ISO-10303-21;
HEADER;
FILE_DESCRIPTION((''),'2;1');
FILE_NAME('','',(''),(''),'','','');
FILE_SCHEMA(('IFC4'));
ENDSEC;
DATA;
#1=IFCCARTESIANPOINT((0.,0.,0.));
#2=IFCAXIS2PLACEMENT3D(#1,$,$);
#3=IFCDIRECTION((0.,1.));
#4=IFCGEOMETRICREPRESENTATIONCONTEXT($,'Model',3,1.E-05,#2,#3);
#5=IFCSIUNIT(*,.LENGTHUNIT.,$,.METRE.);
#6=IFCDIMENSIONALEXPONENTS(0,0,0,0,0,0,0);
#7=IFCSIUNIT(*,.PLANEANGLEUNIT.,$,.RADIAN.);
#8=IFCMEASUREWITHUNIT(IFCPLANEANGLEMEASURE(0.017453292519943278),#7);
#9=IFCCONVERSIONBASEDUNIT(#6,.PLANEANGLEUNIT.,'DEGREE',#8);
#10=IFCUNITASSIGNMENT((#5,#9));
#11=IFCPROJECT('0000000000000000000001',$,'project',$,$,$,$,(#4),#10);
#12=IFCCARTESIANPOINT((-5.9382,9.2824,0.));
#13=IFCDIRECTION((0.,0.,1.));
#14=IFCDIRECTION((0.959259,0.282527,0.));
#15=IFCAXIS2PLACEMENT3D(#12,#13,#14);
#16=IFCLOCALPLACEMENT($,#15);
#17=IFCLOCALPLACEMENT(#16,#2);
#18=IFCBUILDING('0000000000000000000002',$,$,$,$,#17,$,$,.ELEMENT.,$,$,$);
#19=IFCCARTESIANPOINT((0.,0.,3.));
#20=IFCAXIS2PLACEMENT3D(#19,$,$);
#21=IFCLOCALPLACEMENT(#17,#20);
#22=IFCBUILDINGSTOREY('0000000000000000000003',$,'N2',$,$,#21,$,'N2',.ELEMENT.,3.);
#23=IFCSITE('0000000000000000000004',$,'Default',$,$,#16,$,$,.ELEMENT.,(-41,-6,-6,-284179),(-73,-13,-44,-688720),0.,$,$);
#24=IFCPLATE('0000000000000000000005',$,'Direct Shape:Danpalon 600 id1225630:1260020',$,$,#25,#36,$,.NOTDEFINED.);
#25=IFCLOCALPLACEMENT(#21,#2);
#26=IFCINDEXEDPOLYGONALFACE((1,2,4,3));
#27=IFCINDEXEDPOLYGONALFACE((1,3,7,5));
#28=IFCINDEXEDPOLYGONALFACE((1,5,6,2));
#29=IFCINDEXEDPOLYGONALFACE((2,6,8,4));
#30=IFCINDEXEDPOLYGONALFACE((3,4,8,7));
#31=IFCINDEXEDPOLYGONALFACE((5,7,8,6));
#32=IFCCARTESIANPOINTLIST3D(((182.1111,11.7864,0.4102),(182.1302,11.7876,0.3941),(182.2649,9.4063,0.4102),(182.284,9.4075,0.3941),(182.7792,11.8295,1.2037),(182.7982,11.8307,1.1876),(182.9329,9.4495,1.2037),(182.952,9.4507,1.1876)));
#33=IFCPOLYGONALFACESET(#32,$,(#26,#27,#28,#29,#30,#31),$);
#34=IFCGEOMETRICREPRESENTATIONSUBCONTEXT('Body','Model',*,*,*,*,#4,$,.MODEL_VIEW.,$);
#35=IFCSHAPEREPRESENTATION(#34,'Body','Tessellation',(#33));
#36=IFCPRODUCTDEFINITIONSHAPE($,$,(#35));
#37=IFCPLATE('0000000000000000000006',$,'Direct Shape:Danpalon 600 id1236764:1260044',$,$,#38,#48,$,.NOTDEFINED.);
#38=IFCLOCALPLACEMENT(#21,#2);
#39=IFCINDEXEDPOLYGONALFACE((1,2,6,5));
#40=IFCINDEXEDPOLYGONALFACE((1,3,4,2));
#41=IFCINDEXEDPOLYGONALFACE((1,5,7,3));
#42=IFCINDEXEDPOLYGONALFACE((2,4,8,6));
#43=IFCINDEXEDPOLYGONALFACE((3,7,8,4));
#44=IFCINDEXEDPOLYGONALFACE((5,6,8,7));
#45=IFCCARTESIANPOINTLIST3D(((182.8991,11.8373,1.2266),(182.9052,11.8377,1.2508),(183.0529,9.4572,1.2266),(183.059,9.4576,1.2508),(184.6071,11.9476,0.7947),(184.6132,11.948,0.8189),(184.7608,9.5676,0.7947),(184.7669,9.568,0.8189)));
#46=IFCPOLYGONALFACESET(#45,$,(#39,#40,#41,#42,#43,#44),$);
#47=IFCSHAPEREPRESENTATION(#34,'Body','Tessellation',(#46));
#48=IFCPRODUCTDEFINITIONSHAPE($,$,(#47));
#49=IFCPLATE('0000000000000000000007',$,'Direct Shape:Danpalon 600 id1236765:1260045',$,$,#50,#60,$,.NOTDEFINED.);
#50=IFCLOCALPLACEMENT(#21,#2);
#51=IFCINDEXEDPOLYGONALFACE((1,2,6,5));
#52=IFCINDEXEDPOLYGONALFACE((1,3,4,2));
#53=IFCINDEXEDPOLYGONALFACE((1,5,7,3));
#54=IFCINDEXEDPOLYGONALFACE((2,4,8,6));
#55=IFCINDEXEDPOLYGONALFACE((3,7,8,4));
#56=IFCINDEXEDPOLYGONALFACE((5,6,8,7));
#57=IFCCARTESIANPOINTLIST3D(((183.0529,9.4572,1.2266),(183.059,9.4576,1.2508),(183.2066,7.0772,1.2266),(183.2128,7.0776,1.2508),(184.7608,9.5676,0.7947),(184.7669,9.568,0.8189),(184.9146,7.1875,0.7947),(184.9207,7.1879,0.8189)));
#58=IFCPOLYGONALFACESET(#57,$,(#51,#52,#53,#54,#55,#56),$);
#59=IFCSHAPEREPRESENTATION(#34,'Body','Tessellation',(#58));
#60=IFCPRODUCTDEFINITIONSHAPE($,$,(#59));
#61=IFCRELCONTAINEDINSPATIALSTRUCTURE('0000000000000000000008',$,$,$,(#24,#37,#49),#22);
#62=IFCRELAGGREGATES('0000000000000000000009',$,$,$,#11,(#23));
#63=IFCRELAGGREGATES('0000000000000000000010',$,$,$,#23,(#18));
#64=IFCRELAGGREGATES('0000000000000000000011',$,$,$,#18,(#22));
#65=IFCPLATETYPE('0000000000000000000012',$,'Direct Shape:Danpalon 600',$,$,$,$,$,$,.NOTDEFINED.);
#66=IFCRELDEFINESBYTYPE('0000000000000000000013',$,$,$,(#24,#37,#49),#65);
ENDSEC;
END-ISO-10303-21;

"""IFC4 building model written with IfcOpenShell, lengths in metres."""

from ifc_helpers import new_model, entity, si_unit, converted_unit, direction, frame, frame_2d, origin, place, context, subcontext, project, spatial, rectangle, extrude, type_object, element, save


model = new_model("IFC4")

# Units and contexts
model_context = context("Model", 3, precision=1e-05, world=origin(), true_north=direction((0.0, 1.0)))
body_context = subcontext(model_context, "Body", "Model", "MODEL_VIEW")
ifc_project = project(units=[si_unit("LENGTHUNIT", "METRE"), converted_unit("PLANEANGLEUNIT", "DEGREE", entity("IfcPlaneAngleMeasure", 0.017453292519943278), si_unit("PLANEANGLEUNIT", "RADIAN"), dimensions=[0, 0, 0, 0, 0, 0, 0])], contexts=[model_context])

# Site, building, storey
site_placement = place(None, frame((-5.9382, 9.2824, 0.0), z_axis=(0.0, 0.0, 1.0), x_axis=(0.959259, 0.282527, 0.0)))
site = spatial("IfcSite", under=ifc_project, at=site_placement, Name="Default", CompositionType="ELEMENT", RefLatitude=(-41, -6, -6, -284179), RefLongitude=(-73, -13, -44, -688720), RefElevation=0.0)
building_placement = place(site_placement, origin())
building = spatial("IfcBuilding", under=site, at=building_placement, CompositionType="ELEMENT")
storey_placement = place(building_placement, frame((0.0, 0.0, 3.0)))
storey = spatial("IfcBuildingStorey", under=building, at=storey_placement, Name="N2", LongName="N2", CompositionType="ELEMENT", Elevation=3.0)

# Plates
plate_type = type_object("IfcPlateType", Name="Direct Shape:Danpalon 600", PredefinedType="NOTDEFINED")
plate_1_placement = place(storey_placement, origin())
element("IfcPlate", 1, at=plate_1_placement, inside=storey, type_object=plate_type, Name="Direct Shape:Danpalon 600 id1225630:1260020", PredefinedType="NOTDEFINED", context=body_context, shape_type="SweptSolid", body=[
    extrude(rectangle(XDim=1.0381, YDim=0.025, at=frame_2d((0.0, 0.0), x_axis=(0.0, 1.0))), frame((182.6085, 9.4285, 0.7989), z_axis=(-0.064471, 0.99792, 0.0), x_axis=(-0.762714, -0.049276, 0.644857)), (0.0, 0.0, 1.0), 2.385),
])
plate_2_placement = place(storey_placement, origin())
element("IfcPlate", 2, at=plate_2_placement, inside=storey, type_object=plate_type, Name="Direct Shape:Danpalon 600 id1236764:1260044", PredefinedType="NOTDEFINED", context=body_context, shape_type="SweptSolid", body=[
    extrude(rectangle(XDim=0.025, YDim=1.7652, at=frame_2d((0.0, 0.0), x_axis=(1.0, 0.0))), frame((183.9099, 9.5126, 1.0228), z_axis=(-0.064471, 0.99792, 0.0), x_axis=(0.24414, 0.015773, 0.969612)), (0.0, 0.0, 1.0), 2.385),
])
plate_3_placement = place(storey_placement, origin())
element("IfcPlate", 3, at=plate_3_placement, inside=storey, type_object=plate_type, Name="Direct Shape:Danpalon 600 id1236765:1260045", PredefinedType="NOTDEFINED", context=body_context, shape_type="SweptSolid", body=[
    extrude(rectangle(XDim=0.025, YDim=1.7652, at=frame_2d((0.0, 0.0), x_axis=(1.0, 0.0))), frame((184.0637, 7.1326, 1.0228), z_axis=(-0.064471, 0.99792, 0.0), x_axis=(0.24414, 0.015773, 0.969612)), (0.0, 0.0, 1.0), 2.385),
])

save(model, "model.ifc")
